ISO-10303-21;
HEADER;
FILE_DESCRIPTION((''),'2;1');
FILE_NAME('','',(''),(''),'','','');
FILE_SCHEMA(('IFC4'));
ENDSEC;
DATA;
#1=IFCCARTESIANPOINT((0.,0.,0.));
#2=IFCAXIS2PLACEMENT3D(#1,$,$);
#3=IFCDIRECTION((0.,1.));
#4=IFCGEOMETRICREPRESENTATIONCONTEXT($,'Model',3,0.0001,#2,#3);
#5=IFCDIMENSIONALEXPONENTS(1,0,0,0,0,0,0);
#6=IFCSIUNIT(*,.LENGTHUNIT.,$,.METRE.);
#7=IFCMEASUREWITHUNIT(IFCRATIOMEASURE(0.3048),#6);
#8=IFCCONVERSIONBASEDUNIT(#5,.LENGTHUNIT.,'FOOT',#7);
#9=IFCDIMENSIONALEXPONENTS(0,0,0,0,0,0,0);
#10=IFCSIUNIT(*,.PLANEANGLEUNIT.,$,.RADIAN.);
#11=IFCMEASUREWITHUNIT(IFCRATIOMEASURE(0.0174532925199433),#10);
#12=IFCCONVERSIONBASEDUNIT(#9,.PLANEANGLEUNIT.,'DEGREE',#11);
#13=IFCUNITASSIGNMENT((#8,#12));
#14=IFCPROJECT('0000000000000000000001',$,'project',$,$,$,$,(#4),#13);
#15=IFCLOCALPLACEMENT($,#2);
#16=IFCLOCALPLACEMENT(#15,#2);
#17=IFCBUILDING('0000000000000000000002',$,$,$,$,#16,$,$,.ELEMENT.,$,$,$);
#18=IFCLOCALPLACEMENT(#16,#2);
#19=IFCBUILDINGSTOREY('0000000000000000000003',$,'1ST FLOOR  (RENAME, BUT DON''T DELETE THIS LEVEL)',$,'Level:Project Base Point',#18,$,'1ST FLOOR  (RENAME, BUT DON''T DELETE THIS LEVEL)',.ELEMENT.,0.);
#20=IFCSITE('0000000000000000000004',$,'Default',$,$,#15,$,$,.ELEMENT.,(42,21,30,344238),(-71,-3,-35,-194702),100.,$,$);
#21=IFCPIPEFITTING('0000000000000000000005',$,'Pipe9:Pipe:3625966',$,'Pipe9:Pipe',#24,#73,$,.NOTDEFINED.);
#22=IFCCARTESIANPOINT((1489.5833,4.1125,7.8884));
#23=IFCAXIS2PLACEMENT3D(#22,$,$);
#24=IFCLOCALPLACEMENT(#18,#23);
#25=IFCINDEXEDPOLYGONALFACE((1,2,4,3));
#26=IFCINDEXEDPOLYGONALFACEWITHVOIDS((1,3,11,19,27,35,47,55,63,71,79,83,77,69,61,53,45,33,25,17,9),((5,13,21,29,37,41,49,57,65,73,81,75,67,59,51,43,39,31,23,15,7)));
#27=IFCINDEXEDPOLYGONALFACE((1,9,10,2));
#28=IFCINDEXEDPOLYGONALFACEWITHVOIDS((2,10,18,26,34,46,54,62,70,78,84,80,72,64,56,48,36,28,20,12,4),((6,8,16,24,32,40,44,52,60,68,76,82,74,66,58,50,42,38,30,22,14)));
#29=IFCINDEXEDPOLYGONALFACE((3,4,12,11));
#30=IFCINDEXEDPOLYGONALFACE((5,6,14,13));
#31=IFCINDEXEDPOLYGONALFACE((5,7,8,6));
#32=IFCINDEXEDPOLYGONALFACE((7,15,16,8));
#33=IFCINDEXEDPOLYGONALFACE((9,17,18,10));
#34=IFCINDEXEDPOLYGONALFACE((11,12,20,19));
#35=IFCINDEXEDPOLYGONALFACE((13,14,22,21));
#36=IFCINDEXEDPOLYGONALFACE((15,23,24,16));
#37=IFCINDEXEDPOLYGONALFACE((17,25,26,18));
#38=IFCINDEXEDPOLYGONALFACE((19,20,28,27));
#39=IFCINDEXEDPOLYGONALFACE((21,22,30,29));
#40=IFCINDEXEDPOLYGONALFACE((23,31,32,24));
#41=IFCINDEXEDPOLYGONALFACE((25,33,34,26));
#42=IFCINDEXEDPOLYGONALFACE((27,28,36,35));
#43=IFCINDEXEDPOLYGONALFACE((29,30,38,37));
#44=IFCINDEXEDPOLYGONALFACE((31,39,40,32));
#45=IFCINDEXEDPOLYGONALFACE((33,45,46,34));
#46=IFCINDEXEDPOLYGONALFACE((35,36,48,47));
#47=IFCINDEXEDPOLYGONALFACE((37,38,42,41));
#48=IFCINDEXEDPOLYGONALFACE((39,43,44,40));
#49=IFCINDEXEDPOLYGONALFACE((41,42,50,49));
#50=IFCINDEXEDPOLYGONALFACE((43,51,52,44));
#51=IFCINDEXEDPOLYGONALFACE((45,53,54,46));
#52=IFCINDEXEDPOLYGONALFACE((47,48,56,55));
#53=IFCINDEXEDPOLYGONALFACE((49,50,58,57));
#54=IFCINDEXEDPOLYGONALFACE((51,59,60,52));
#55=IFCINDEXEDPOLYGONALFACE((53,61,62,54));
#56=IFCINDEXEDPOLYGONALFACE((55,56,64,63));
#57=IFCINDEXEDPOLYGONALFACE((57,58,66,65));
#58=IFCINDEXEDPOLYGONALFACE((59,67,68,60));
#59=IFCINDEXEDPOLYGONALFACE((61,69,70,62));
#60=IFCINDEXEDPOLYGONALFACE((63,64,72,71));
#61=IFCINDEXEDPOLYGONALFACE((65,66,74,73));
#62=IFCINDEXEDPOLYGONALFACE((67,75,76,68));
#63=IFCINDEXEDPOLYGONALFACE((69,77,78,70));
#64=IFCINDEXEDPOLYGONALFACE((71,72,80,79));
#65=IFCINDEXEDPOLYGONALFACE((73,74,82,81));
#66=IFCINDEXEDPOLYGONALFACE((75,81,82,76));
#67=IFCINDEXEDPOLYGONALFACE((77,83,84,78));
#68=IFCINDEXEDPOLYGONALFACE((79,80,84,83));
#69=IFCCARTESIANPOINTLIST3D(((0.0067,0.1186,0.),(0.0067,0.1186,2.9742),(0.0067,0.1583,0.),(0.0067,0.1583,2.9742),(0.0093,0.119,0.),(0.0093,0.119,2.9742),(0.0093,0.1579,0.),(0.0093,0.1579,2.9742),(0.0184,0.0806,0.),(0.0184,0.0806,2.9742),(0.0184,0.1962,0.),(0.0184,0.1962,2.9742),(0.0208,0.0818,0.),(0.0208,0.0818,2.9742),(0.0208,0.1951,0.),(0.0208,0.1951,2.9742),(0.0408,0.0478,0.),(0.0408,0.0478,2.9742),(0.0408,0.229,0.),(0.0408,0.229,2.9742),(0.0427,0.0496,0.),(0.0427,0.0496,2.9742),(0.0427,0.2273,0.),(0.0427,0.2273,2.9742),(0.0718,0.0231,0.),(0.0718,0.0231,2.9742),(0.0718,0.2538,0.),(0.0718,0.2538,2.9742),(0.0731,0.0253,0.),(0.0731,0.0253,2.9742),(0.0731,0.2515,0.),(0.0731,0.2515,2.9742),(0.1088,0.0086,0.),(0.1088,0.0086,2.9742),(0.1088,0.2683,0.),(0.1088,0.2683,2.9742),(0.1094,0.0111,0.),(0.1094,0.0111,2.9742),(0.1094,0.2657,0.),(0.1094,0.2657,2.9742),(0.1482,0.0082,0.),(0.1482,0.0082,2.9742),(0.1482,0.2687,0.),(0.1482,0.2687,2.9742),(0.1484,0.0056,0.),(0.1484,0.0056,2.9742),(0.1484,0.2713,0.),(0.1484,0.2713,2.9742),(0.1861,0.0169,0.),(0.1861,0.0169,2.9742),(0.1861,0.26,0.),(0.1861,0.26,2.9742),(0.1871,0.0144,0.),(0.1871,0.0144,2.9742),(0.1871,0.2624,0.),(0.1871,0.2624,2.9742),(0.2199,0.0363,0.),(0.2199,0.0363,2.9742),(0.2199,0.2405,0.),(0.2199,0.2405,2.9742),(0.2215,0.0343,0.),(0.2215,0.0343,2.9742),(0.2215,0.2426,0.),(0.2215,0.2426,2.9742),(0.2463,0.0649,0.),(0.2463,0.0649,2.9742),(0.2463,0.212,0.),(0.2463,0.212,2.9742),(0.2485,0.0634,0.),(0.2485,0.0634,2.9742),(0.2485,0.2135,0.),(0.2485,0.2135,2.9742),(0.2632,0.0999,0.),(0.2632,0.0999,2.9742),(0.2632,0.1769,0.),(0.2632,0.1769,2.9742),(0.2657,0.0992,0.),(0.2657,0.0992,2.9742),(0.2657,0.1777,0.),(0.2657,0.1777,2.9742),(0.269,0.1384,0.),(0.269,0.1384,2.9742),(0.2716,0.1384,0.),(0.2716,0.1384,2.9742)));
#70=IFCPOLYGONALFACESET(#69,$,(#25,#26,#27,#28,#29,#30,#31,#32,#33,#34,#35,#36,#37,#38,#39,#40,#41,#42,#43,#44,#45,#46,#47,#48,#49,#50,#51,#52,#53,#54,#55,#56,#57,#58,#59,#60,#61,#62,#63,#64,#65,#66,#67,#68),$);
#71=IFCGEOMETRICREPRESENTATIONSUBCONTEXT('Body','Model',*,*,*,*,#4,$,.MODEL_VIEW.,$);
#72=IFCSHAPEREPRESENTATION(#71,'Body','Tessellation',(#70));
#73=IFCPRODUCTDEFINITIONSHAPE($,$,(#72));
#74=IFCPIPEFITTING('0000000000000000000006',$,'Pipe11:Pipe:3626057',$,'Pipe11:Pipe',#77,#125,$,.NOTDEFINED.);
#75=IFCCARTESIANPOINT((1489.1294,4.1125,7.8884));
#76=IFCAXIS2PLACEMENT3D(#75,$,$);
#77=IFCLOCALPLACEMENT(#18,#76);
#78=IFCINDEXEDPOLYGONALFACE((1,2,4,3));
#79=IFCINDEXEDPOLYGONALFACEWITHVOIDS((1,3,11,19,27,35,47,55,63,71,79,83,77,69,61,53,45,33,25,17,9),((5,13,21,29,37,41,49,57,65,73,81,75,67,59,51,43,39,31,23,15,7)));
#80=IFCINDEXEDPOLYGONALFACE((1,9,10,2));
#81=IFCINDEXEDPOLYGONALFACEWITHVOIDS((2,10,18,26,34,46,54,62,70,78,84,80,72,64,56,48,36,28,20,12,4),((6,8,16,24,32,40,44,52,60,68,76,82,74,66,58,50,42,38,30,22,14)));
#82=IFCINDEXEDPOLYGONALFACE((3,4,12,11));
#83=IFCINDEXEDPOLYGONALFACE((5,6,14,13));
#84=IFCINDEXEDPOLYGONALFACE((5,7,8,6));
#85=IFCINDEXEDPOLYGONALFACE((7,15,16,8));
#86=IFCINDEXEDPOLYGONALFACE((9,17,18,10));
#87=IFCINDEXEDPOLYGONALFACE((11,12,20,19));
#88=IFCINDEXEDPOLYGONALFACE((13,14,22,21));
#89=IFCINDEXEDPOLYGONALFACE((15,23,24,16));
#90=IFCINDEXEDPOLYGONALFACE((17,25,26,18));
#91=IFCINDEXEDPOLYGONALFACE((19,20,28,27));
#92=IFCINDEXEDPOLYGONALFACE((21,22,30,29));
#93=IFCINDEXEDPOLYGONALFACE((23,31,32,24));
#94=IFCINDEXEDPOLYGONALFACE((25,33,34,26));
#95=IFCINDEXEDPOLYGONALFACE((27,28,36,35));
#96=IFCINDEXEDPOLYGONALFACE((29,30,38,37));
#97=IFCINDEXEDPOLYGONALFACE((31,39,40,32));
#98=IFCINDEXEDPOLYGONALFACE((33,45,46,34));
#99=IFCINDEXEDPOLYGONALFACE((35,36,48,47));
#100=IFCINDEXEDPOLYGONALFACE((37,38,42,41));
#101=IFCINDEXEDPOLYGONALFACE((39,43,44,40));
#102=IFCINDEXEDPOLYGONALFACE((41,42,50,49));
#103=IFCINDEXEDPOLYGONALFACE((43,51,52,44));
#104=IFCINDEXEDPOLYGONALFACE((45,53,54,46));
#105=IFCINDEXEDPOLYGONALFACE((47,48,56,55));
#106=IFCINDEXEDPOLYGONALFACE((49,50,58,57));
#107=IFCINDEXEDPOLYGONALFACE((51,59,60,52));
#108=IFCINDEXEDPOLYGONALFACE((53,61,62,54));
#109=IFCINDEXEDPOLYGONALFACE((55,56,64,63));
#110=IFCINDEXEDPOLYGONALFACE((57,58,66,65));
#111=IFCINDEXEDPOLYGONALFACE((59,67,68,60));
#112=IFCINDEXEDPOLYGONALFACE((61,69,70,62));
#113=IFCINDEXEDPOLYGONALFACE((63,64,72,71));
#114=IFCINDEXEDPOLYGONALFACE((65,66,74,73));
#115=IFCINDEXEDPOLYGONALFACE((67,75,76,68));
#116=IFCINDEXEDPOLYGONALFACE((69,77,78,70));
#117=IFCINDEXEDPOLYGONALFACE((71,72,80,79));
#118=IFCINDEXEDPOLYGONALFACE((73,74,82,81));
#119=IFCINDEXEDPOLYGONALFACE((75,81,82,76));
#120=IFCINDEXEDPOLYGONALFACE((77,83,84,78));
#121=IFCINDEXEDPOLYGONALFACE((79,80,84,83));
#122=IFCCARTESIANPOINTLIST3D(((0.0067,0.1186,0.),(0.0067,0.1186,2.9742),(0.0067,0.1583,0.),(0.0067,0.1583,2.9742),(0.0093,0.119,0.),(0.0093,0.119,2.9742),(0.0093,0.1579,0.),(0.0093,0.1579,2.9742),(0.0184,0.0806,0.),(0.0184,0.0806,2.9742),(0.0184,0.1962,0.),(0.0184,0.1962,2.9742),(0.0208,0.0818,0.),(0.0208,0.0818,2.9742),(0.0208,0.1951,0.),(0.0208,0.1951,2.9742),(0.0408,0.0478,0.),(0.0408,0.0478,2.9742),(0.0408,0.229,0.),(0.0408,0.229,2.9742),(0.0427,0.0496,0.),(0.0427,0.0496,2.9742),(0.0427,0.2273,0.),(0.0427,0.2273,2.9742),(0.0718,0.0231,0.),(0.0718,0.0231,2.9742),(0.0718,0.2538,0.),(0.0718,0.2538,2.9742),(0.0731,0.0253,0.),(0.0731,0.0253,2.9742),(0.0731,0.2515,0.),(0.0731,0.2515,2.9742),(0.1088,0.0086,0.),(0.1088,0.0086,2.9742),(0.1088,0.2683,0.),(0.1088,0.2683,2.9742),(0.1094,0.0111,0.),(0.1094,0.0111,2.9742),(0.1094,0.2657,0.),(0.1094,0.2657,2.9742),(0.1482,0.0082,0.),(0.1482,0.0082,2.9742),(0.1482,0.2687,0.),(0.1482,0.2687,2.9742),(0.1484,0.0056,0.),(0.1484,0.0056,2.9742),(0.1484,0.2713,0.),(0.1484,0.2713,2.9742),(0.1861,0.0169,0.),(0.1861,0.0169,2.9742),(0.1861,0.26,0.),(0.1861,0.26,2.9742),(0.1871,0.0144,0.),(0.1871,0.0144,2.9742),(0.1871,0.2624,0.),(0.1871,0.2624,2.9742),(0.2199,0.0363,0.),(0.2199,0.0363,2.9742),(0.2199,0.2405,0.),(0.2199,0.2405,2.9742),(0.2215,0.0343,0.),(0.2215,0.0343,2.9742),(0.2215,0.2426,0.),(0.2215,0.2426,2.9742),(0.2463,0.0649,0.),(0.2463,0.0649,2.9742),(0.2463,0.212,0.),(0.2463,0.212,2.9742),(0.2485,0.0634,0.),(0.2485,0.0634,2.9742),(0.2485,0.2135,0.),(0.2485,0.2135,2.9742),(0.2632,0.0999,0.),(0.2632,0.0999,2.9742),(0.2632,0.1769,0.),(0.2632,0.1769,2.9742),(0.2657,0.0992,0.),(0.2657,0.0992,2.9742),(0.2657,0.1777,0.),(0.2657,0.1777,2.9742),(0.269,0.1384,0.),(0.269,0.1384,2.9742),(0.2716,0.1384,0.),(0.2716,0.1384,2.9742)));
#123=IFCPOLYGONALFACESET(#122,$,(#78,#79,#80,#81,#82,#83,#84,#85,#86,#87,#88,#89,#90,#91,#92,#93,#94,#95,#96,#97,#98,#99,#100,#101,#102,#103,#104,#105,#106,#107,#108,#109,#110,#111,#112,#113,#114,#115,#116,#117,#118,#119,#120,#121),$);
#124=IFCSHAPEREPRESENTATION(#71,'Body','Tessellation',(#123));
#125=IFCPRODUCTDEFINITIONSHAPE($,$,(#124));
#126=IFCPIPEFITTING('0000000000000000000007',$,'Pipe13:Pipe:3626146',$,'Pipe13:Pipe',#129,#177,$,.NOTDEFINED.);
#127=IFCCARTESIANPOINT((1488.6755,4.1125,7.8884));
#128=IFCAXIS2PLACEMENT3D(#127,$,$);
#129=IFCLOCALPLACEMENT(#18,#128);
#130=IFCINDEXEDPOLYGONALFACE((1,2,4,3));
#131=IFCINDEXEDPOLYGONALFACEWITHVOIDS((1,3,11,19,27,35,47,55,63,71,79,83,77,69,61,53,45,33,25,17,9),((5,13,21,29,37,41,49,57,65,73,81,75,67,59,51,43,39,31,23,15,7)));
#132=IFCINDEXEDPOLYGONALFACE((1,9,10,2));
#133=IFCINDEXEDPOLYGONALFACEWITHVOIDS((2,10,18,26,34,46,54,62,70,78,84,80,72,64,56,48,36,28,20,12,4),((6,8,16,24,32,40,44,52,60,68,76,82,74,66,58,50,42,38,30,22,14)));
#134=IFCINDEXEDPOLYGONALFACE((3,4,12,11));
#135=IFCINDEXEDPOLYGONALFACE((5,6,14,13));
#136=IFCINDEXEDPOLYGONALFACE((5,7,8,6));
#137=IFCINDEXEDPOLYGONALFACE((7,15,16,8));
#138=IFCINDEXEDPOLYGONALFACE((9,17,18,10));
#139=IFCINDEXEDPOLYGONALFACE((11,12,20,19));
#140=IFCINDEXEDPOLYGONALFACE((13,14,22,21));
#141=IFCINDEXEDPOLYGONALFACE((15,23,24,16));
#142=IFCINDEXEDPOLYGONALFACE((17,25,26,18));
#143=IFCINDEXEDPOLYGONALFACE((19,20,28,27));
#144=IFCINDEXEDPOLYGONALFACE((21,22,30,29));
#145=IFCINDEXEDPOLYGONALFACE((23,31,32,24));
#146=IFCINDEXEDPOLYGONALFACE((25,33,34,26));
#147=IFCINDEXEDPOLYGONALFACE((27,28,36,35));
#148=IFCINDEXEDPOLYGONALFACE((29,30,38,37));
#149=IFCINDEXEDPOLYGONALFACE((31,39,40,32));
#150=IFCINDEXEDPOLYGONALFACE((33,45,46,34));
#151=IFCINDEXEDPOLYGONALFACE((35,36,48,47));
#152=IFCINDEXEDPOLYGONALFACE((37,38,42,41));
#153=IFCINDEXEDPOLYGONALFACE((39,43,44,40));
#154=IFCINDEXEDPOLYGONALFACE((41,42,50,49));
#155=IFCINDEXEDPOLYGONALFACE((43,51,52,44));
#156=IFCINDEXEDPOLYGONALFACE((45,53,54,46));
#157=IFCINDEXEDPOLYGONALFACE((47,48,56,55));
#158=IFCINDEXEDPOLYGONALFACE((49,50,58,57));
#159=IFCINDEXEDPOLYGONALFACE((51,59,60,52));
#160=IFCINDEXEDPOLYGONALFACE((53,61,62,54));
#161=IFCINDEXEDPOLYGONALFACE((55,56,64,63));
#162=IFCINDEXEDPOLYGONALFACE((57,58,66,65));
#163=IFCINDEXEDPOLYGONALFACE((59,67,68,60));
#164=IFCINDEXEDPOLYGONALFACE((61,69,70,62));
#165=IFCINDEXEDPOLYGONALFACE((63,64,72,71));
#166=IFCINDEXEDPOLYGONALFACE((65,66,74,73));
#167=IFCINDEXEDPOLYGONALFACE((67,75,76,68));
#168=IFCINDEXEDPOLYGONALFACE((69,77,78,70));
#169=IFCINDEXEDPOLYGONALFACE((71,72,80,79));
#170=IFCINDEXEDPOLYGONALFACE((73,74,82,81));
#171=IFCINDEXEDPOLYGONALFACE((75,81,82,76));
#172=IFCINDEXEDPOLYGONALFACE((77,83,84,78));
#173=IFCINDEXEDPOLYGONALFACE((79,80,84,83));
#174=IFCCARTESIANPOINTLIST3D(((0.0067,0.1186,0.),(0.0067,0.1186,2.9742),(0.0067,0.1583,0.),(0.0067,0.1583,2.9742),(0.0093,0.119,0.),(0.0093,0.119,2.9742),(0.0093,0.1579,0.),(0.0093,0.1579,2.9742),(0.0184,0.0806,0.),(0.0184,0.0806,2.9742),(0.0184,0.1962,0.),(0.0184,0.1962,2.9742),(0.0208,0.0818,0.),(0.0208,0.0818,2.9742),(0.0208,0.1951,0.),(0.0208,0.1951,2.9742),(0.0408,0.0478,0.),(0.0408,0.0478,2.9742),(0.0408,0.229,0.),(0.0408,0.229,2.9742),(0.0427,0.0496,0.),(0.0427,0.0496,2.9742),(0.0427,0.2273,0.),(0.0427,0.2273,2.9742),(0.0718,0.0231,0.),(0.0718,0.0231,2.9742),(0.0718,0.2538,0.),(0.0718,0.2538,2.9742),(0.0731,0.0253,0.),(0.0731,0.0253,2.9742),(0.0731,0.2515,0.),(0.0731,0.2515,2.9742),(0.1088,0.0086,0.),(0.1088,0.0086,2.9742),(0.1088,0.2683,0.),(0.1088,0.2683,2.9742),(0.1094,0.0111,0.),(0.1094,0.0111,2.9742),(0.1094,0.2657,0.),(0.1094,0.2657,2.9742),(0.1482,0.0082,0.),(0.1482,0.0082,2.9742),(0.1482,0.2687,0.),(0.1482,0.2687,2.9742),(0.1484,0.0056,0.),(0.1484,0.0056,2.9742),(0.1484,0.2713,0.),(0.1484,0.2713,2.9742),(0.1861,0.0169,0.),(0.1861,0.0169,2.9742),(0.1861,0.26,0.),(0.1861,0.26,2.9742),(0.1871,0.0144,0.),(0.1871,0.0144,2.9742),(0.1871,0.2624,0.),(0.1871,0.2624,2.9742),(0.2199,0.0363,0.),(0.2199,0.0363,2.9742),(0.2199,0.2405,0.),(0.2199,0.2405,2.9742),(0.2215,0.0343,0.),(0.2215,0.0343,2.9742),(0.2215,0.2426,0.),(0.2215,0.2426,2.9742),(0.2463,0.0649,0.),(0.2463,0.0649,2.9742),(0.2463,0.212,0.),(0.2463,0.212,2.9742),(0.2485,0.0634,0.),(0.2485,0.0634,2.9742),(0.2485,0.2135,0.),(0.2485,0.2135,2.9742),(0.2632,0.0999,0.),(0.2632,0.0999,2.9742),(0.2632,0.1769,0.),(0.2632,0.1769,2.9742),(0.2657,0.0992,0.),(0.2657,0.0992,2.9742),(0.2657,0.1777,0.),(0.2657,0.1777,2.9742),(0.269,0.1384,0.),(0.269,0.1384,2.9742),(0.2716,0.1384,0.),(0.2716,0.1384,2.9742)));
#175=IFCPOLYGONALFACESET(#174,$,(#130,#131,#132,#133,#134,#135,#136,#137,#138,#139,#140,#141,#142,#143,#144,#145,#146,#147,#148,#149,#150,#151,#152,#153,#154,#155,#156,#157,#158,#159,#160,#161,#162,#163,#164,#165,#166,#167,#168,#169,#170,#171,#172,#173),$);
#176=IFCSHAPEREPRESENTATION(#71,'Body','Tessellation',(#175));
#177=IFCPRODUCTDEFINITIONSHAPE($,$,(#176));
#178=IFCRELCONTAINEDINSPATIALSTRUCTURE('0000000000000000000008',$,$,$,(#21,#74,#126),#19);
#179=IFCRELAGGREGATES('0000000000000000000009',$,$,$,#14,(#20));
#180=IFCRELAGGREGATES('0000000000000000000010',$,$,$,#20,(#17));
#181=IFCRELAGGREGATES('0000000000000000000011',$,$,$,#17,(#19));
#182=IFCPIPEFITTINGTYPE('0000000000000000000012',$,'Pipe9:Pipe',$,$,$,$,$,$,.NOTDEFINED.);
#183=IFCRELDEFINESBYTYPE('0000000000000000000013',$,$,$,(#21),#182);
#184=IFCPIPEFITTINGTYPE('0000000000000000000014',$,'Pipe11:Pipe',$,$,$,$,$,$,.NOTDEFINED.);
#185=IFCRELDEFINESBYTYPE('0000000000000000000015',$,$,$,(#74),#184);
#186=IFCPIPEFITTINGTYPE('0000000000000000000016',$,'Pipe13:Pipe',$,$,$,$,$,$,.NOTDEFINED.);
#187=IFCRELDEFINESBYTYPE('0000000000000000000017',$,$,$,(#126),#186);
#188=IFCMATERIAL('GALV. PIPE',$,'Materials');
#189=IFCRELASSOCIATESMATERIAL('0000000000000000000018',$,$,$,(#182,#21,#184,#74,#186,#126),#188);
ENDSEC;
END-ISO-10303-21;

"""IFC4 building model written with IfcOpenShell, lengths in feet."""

from ifc_helpers import new_model, entity, si_unit, converted_unit, direction, frame, frame_2d, origin, place, context, subcontext, project, spatial, hollow_circle, extrude, source, transform, mapped, material, type_object, type_shapes, element, save


model = new_model("IFC4")

# Units and contexts
model_context = context("Model", 3, precision=0.0001, world=origin(), true_north=direction((0.0, 1.0)))
body_context = subcontext(model_context, "Body", "Model", "MODEL_VIEW")
ifc_project = project(units=[converted_unit("LENGTHUNIT", "FOOT", entity("IfcRatioMeasure", 0.3048), si_unit("LENGTHUNIT", "METRE"), dimensions=[1, 0, 0, 0, 0, 0, 0]), converted_unit("PLANEANGLEUNIT", "DEGREE", entity("IfcRatioMeasure", 0.0174532925199433), si_unit("PLANEANGLEUNIT", "RADIAN"), dimensions=[0, 0, 0, 0, 0, 0, 0])], contexts=[model_context])

# Site, building, storey
site_placement = place(None, origin())
site = spatial("IfcSite", under=ifc_project, at=site_placement, Name="Default", CompositionType="ELEMENT", RefLatitude=(42, 21, 30, 344238), RefLongitude=(-71, -3, -35, -194702), RefElevation=100.0)
building_placement = place(site_placement, origin())
building = spatial("IfcBuilding", under=site, at=building_placement, CompositionType="ELEMENT")
storey_placement = place(building_placement, origin())
storey = spatial("IfcBuildingStorey", under=building, at=storey_placement, Name="1ST FLOOR  (RENAME, BUT DON'T DELETE THIS LEVEL)", ObjectType="Level:Project Base Point", LongName="1ST FLOOR  (RENAME, BUT DON'T DELETE THIS LEVEL)", CompositionType="ELEMENT", Elevation=0.0)

# Shared definitions
ifc_material_1 = material(Name="GALV. PIPE", Category="Materials")

# Pipe fitting
pipe_fitting_type_1 = type_object("IfcPipeFittingType", Name="Pipe9:Pipe", PredefinedType="NOTDEFINED", material=ifc_material_1)
shared_shape_1 = source(origin(), body_context, "Body", "SweptSolid", [
    extrude(hollow_circle(Radius=0.1332, WallThickness=0.0026, at=frame_2d((0.0, 0.0), x_axis=(1.0, 0.0))), frame((0.1384, 0.1384, 0.0)), (0.0, 0.0, 1.0), 2.9742),
])
type_shapes(pipe_fitting_type_1, [shared_shape_1])
pipe_fitting_1_placement = place(storey_placement, frame((1489.5833, 4.1125, 7.8884)))
element("IfcPipeFitting", 1, at=pipe_fitting_1_placement, inside=storey, type_object=pipe_fitting_type_1, material=ifc_material_1, Name="Pipe9:Pipe:3625966", ObjectType="Pipe9:Pipe", PredefinedType="NOTDEFINED", context=body_context, shape_type="MappedRepresentation", body=[
    mapped(shared_shape_1, transform((0.0, 0.0, 0.0), scale=1.0)),
])

# Pipe fitting
pipe_fitting_type_2 = type_object("IfcPipeFittingType", Name="Pipe11:Pipe", PredefinedType="NOTDEFINED", material=ifc_material_1)
shared_shape_2 = source(origin(), body_context, "Body", "SweptSolid", [
    extrude(hollow_circle(Radius=0.1332, WallThickness=0.0026, at=frame_2d((0.0, 0.0), x_axis=(1.0, 0.0))), frame((0.1384, 0.1384, 0.0)), (0.0, 0.0, 1.0), 2.9742),
])
type_shapes(pipe_fitting_type_2, [shared_shape_2])
pipe_fitting_2_placement = place(storey_placement, frame((1489.1294, 4.1125, 7.8884)))
element("IfcPipeFitting", 2, at=pipe_fitting_2_placement, inside=storey, type_object=pipe_fitting_type_2, material=ifc_material_1, Name="Pipe11:Pipe:3626057", ObjectType="Pipe11:Pipe", PredefinedType="NOTDEFINED", context=body_context, shape_type="MappedRepresentation", body=[
    mapped(shared_shape_2, transform((0.0, 0.0, 0.0), scale=1.0)),
])

# Pipe fitting
pipe_fitting_type_3 = type_object("IfcPipeFittingType", Name="Pipe13:Pipe", PredefinedType="NOTDEFINED", material=ifc_material_1)
shared_shape_3 = source(origin(), body_context, "Body", "SweptSolid", [
    extrude(hollow_circle(Radius=0.1332, WallThickness=0.0026, at=frame_2d((0.0, 0.0), x_axis=(1.0, 0.0))), frame((0.1384, 0.1384, 0.0)), (0.0, 0.0, 1.0), 2.9742),
])
type_shapes(pipe_fitting_type_3, [shared_shape_3])
pipe_fitting_3_placement = place(storey_placement, frame((1488.6755, 4.1125, 7.8884)))
element("IfcPipeFitting", 3, at=pipe_fitting_3_placement, inside=storey, type_object=pipe_fitting_type_3, material=ifc_material_1, Name="Pipe13:Pipe:3626146", ObjectType="Pipe13:Pipe", PredefinedType="NOTDEFINED", context=body_context, shape_type="MappedRepresentation", body=[
    mapped(shared_shape_3, transform((0.0, 0.0, 0.0), scale=1.0)),
])

save(model, "model.ifc")
